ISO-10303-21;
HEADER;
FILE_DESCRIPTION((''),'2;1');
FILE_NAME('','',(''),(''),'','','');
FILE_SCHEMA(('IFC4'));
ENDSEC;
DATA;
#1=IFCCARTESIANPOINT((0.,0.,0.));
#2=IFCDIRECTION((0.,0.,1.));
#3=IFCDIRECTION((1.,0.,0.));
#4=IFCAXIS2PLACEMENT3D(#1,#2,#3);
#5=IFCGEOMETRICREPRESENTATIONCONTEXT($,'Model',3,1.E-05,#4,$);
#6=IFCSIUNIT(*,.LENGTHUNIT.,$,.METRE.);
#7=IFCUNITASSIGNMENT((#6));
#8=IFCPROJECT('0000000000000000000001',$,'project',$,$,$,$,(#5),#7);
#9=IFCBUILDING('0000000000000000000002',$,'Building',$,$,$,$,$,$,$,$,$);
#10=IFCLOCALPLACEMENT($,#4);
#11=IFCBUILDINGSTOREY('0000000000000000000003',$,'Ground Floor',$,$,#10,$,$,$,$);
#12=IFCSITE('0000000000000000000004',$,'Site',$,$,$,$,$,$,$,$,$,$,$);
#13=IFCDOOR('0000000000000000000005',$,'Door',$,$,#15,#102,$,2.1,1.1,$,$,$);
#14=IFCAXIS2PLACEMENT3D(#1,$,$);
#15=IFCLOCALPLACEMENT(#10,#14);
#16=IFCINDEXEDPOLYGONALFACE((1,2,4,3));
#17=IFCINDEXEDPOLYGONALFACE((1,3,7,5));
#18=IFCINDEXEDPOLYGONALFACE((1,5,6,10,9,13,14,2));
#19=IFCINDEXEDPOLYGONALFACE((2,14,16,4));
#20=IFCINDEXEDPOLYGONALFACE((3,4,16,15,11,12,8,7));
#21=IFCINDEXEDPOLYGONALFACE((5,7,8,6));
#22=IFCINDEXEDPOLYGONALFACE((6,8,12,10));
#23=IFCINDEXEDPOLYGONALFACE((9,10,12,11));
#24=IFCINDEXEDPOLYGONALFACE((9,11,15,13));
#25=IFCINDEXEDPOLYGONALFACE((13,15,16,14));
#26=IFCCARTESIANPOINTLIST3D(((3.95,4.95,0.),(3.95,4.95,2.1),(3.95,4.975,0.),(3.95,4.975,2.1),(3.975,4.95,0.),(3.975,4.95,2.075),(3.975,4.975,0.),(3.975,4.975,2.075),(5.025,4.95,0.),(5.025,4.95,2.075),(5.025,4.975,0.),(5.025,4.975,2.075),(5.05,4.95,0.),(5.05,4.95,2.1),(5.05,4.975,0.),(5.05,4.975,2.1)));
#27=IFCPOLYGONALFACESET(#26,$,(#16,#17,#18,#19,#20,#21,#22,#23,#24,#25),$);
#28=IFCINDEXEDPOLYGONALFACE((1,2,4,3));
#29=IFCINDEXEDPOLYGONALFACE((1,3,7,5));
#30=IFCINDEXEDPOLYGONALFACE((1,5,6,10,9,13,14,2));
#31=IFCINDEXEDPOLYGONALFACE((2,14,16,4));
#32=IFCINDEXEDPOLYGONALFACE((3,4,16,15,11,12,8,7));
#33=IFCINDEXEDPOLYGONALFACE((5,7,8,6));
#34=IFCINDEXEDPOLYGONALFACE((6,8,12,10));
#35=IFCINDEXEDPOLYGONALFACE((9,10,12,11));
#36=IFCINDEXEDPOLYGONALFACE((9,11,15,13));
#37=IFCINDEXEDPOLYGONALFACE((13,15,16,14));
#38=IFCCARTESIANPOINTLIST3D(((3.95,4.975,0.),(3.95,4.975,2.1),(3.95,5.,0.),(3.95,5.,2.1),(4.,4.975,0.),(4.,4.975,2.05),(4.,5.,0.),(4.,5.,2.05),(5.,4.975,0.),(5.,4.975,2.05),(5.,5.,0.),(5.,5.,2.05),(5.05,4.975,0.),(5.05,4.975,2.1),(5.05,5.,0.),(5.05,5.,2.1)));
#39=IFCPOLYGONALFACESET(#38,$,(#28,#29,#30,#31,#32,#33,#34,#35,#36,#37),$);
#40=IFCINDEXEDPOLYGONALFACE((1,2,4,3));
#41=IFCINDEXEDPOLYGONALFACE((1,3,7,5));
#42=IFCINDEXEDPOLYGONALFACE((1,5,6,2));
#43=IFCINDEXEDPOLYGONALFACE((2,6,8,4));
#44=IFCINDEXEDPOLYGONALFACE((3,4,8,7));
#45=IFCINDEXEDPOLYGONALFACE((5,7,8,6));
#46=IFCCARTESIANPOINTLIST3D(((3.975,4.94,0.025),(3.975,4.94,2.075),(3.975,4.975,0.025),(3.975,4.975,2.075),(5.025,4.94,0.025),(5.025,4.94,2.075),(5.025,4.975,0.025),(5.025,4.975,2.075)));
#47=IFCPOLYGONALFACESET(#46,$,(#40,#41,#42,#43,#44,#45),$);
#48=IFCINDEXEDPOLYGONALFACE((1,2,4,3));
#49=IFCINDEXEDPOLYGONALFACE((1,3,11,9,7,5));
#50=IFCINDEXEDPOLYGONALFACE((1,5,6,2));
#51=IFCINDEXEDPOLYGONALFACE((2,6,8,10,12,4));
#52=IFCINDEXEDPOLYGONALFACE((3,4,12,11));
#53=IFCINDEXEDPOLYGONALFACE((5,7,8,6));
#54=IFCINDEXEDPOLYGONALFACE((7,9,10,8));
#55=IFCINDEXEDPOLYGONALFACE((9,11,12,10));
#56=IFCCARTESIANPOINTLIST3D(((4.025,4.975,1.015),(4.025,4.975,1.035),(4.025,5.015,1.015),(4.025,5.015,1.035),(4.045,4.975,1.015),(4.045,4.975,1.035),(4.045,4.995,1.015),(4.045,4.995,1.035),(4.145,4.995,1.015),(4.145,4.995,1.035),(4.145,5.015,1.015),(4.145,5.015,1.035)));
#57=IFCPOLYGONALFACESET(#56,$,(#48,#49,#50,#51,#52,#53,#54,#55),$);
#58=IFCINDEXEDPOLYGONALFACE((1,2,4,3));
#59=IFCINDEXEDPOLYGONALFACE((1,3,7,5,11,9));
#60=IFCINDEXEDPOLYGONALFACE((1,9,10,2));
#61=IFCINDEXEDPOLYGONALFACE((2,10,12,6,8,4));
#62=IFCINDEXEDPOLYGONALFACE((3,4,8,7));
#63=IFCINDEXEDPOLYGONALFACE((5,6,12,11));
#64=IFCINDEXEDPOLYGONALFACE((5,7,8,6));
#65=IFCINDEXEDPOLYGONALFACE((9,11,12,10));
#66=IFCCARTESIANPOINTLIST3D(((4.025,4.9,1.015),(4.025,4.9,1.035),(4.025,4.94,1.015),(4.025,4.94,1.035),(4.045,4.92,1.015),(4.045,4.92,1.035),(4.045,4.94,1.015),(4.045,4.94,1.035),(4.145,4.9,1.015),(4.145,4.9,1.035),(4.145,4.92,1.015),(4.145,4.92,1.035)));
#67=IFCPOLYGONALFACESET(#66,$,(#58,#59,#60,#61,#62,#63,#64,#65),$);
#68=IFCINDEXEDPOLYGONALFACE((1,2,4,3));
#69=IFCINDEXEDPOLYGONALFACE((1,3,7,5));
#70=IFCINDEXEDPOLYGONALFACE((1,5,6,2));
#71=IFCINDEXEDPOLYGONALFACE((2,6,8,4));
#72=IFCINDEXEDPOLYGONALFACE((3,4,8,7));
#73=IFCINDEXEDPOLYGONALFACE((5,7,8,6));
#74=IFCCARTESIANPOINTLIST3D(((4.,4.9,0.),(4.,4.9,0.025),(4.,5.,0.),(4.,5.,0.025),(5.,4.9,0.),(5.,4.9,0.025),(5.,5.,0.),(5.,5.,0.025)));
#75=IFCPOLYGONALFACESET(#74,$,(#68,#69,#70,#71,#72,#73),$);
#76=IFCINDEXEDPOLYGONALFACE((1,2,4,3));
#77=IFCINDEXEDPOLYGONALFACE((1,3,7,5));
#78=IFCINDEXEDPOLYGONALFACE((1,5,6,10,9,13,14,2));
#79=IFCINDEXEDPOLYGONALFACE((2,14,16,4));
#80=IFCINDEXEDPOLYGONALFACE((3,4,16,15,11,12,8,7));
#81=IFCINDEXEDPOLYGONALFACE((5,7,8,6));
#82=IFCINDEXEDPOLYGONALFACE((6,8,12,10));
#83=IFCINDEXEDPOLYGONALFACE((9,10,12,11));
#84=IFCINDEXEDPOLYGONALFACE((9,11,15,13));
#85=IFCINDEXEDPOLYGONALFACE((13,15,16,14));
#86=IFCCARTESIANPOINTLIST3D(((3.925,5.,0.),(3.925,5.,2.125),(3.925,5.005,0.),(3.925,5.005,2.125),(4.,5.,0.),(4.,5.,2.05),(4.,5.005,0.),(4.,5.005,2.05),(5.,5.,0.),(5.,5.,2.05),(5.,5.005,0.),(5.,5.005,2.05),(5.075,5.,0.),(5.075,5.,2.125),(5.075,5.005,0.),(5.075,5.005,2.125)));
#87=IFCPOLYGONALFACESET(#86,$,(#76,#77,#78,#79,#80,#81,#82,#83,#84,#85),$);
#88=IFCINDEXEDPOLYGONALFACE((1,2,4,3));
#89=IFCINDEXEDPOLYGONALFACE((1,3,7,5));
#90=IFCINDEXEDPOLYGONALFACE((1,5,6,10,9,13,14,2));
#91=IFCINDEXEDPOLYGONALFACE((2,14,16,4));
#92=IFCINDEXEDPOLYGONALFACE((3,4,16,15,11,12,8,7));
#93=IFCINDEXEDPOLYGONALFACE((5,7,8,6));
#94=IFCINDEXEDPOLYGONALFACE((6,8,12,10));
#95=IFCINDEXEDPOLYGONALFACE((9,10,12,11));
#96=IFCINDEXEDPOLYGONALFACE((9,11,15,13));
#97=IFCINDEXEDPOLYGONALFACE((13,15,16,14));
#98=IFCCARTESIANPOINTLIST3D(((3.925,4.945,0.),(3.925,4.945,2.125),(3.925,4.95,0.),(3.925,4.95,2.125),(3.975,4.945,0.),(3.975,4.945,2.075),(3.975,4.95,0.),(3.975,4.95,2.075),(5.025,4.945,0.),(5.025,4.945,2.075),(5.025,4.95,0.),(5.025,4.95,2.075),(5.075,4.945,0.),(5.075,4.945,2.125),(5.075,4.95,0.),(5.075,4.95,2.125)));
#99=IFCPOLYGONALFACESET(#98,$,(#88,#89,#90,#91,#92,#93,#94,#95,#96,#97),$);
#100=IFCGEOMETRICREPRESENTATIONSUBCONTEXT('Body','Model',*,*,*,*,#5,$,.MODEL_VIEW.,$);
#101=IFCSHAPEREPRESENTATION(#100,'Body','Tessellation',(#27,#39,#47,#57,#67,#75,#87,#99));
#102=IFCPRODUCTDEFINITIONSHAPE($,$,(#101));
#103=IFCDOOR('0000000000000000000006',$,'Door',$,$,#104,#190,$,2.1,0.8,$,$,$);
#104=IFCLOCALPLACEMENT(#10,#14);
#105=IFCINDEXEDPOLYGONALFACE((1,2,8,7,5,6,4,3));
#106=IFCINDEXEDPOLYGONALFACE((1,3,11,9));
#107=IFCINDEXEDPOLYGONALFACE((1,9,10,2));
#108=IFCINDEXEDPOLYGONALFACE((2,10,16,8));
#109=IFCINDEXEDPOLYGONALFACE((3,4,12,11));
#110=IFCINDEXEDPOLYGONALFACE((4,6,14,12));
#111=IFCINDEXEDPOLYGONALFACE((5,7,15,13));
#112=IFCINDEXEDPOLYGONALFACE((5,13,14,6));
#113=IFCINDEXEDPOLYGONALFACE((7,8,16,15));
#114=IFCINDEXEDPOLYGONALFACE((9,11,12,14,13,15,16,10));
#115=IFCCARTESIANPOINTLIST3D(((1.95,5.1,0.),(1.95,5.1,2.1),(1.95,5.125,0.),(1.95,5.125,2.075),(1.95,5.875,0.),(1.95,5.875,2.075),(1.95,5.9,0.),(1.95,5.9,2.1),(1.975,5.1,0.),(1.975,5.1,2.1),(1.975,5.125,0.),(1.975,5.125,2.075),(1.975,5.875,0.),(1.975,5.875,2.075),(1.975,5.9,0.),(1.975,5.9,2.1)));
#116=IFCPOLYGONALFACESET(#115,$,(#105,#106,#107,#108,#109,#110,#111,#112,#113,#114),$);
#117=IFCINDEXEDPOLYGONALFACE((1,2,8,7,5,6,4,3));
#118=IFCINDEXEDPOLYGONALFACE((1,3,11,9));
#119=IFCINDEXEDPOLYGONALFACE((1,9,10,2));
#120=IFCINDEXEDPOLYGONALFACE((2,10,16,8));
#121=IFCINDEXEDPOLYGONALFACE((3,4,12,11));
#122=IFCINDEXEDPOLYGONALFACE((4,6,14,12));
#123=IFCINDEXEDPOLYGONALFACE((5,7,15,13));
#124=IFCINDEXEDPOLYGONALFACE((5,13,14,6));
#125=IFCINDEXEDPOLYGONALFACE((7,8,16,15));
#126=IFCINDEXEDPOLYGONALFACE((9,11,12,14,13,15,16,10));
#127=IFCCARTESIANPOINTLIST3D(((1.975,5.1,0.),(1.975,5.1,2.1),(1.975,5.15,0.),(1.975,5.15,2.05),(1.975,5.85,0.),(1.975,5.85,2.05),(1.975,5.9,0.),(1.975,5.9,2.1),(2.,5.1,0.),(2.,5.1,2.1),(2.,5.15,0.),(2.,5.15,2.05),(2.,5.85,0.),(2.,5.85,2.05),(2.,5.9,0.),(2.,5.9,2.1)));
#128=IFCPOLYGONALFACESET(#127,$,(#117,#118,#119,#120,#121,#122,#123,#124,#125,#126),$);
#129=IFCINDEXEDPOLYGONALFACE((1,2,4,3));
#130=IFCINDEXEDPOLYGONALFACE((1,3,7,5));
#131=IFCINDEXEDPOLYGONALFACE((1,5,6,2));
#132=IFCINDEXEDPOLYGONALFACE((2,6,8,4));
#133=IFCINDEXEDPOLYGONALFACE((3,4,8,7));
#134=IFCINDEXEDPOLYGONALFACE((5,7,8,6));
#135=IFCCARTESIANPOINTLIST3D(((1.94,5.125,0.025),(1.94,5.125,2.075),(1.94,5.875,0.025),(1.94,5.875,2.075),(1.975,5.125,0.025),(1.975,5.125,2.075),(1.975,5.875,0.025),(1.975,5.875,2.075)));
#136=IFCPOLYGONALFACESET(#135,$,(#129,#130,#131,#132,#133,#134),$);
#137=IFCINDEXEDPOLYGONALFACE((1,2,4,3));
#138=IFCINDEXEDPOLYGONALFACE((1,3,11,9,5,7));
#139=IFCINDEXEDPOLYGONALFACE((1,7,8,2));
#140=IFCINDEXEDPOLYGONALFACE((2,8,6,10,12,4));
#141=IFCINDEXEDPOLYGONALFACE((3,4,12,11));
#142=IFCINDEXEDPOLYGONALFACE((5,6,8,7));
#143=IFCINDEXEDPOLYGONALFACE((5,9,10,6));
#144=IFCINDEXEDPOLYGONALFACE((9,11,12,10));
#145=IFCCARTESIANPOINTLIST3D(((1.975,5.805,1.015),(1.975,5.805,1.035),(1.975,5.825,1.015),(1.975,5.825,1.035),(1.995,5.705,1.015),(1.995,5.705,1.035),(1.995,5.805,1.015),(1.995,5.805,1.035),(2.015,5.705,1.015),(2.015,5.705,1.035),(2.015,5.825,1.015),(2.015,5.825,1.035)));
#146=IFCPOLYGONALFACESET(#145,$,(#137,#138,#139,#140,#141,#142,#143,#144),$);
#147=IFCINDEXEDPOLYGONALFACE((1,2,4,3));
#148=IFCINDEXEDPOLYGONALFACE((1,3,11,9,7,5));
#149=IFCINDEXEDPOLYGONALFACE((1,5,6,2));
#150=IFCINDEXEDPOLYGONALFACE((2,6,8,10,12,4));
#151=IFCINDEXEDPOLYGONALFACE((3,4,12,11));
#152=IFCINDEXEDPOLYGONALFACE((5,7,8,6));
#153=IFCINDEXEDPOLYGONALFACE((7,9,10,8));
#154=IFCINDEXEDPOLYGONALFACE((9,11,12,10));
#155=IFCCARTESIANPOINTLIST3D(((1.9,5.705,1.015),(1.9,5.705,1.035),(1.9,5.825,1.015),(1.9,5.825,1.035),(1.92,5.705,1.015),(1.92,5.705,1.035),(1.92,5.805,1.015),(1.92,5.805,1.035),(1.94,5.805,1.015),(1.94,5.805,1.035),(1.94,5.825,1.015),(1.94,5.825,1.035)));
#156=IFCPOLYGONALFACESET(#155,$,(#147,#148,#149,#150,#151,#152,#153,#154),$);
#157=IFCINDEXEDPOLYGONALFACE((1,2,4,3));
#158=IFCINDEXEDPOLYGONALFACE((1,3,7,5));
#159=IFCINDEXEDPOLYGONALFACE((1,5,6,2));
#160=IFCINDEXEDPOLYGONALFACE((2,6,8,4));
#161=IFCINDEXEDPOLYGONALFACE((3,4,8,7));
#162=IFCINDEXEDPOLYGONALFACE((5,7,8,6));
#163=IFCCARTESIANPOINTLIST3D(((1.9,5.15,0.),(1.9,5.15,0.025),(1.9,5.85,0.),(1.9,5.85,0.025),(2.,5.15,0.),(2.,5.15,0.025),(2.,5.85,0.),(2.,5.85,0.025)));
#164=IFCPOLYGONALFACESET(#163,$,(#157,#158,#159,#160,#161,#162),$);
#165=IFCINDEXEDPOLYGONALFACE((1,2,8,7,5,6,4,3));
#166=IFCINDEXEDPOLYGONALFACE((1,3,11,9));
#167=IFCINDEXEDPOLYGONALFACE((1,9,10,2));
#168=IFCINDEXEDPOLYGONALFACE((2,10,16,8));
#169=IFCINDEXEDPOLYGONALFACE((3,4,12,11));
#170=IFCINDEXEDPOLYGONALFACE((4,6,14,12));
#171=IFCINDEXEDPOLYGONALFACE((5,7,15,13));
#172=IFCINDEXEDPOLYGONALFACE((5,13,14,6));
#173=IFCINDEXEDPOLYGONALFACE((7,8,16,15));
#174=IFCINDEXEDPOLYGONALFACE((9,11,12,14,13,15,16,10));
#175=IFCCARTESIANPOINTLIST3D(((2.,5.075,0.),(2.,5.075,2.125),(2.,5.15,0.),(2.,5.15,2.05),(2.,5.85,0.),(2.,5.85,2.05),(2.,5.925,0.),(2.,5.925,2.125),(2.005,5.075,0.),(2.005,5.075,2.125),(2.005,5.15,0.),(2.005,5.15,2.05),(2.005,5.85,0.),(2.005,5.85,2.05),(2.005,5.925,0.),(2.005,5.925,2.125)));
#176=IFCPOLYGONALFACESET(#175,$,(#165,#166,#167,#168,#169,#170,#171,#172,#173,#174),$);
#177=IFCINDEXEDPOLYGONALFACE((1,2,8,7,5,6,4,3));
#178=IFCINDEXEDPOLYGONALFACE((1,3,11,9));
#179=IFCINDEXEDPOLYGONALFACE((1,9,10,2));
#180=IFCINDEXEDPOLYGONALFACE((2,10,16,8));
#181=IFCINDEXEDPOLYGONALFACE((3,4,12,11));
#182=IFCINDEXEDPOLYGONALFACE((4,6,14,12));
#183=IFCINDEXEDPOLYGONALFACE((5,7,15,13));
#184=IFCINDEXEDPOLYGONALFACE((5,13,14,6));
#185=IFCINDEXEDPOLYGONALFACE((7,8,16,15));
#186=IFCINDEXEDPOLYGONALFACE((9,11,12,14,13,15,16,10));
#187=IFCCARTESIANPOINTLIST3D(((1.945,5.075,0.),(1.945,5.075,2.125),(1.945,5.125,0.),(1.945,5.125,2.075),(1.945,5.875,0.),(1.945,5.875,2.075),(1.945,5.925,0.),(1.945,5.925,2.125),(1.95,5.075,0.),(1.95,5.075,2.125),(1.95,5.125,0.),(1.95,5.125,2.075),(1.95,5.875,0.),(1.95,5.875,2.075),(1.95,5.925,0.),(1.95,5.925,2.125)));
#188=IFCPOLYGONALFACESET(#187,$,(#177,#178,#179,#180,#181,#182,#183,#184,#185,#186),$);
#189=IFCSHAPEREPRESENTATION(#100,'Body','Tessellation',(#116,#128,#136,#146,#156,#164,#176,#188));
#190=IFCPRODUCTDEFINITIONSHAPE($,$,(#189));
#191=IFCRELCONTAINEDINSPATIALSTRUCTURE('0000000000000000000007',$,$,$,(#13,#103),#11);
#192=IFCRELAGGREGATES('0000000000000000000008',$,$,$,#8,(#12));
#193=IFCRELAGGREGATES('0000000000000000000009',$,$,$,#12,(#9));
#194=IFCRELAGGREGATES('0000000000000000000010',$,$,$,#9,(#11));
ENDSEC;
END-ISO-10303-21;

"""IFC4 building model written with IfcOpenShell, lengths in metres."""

from ifc_helpers import new_model, si_unit, frame, origin_with_axes, place, context, subcontext, project, spatial, line, indexed_curve, outline, extrude, element, save


model = new_model("IFC4")

# Units and contexts
model_context = context("Model", 3, precision=1e-05, world=origin_with_axes())
body_context = subcontext(model_context, "Body", "Model", "MODEL_VIEW")
ifc_project = project(units=[si_unit("LENGTHUNIT", "METRE")], contexts=[model_context])

# Site, building, storey
site = spatial("IfcSite", under=ifc_project, Name="Site")
building = spatial("IfcBuilding", under=site, Name="Building")
storey_placement = place(None, origin_with_axes())
storey = spatial("IfcBuildingStorey", under=building, at=storey_placement, Name="Ground Floor")

# Doors
door_1_placement = place(storey_placement, frame((5.05, 5.0, 0.0), z_axis=(0.0, 0.0, 1.0), x_axis=(-1.0, 0.0, 0.0)))
element("IfcDoor", 1, at=door_1_placement, inside=storey, Name="Door", OverallHeight=2.1, OverallWidth=1.1, context=body_context, shape_type="SweptSolid", body=[
    extrude(outline(indexed_curve([(0.0, 0.0), (0.0, 2.1), (1.1, 2.1), (1.1, 0.0), (1.075, 0.0), (1.075, 2.075), (0.025, 2.075), (0.025, 0.0)], segments=[line(1, 2, 3, 4, 5, 6, 7, 8, 1)])), frame((0.0, 0.025, 0.0), z_axis=(0.0, -1.0, 0.0), x_axis=(1.0, 0.0, 0.0)), (0.0, 0.0, -1.0), 0.025),
    extrude(outline(indexed_curve([(0.0, 0.0), (0.0, 2.1), (1.1, 2.1), (1.1, 0.0), (1.05, 0.0), (1.05, 2.05), (0.05, 2.05), (0.05, 0.0)], segments=[line(1, 2, 3, 4, 5, 6, 7, 8, 1)])), frame((0.0, 0.0, 0.0), z_axis=(0.0, -1.0, 0.0), x_axis=(1.0, 0.0, 0.0)), (0.0, 0.0, -1.0), 0.025),
    extrude(outline(indexed_curve([(0.0, 0.0), (1.05, 0.0), (1.05, 0.035), (0.0, 0.035)], segments=[line(1, 2, 3, 4, 1)])), frame((0.025, 0.025, 0.025), z_axis=(0.0, 0.0, 1.0), x_axis=(1.0, 0.0, 0.0)), (0.0, 0.0, 1.0), 2.05),
    extrude(outline(indexed_curve([(0.0, 0.0), (0.0, -0.04), (-0.12, -0.04), (-0.12, -0.02), (-0.02, -0.02), (-0.02, 0.0)], segments=[line(1, 2, 3, 4, 5, 6, 1)])), frame((1.025, 0.025, 1.015), z_axis=(0.0, 0.0, 1.0), x_axis=(1.0, 0.0, 0.0)), (0.0, 0.0, 1.0), 0.02),
    extrude(outline(indexed_curve([(0.0, 0.0), (0.0, 0.04), (-0.12, 0.04), (-0.12, 0.02), (-0.02, 0.02), (-0.02, 0.0)], segments=[line(1, 2, 3, 4, 5, 6, 1)])), frame((1.025, 0.06, 1.015), z_axis=(0.0, 0.0, 1.0), x_axis=(1.0, 0.0, 0.0)), (0.0, 0.0, 1.0), 0.02),
    extrude(outline(indexed_curve([(0.0, 0.0), (1.0, 0.0), (1.0, 0.1), (0.0, 0.1)], segments=[line(1, 2, 3, 4, 1)])), frame((0.05, 0.0, 0.0), z_axis=(0.0, 0.0, 1.0), x_axis=(1.0, 0.0, 0.0)), (0.0, 0.0, 1.0), 0.025),
    extrude(outline(indexed_curve([(0.0, 0.0), (0.0, 2.125), (1.15, 2.125), (1.15, 0.0), (1.075, 0.0), (1.075, 2.05), (0.075, 2.05), (0.075, 0.0)], segments=[line(1, 2, 3, 4, 5, 6, 7, 8, 1)])), frame((-0.025, -0.005, 0.0), z_axis=(0.0, -1.0, 0.0), x_axis=(1.0, 0.0, 0.0)), (0.0, 0.0, -1.0), 0.005),
    extrude(outline(indexed_curve([(0.0, 0.0), (0.0, 2.125), (1.15, 2.125), (1.15, 0.0), (1.1, 0.0), (1.1, 2.075), (0.05, 2.075), (0.05, 0.0)], segments=[line(1, 2, 3, 4, 5, 6, 7, 8, 1)])), frame((-0.025, 0.05, 0.0), z_axis=(0.0, -1.0, 0.0), x_axis=(1.0, 0.0, 0.0)), (0.0, 0.0, -1.0), 0.005),
])
door_2_placement = place(storey_placement, frame((2.0, 5.1, 0.0), z_axis=(0.0, 0.0, 1.0), x_axis=(0.0, 1.0, 0.0)))
element("IfcDoor", 2, at=door_2_placement, inside=storey, Name="Door", OverallHeight=2.1, OverallWidth=0.8, context=body_context, shape_type="SweptSolid", body=[
    extrude(outline(indexed_curve([(0.0, 0.0), (0.0, 2.1), (0.8, 2.1), (0.8, 0.0), (0.775, 0.0), (0.775, 2.075), (0.025, 2.075), (0.025, 0.0)], segments=[line(1, 2, 3, 4, 5, 6, 7, 8, 1)])), frame((0.0, 0.025, 0.0), z_axis=(0.0, -1.0, 0.0), x_axis=(1.0, 0.0, 0.0)), (0.0, 0.0, -1.0), 0.025),
    extrude(outline(indexed_curve([(0.0, 0.0), (0.0, 2.1), (0.8, 2.1), (0.8, 0.0), (0.75, 0.0), (0.75, 2.05), (0.05, 2.05), (0.05, 0.0)], segments=[line(1, 2, 3, 4, 5, 6, 7, 8, 1)])), frame((0.0, 0.0, 0.0), z_axis=(0.0, -1.0, 0.0), x_axis=(1.0, 0.0, 0.0)), (0.0, 0.0, -1.0), 0.025),
    extrude(outline(indexed_curve([(0.0, 0.0), (0.75, 0.0), (0.75, 0.035), (0.0, 0.035)], segments=[line(1, 2, 3, 4, 1)])), frame((0.025, 0.025, 0.025), z_axis=(0.0, 0.0, 1.0), x_axis=(1.0, 0.0, 0.0)), (0.0, 0.0, 1.0), 2.05),
    extrude(outline(indexed_curve([(0.0, 0.0), (0.0, -0.04), (-0.12, -0.04), (-0.12, -0.02), (-0.02, -0.02), (-0.02, 0.0)], segments=[line(1, 2, 3, 4, 5, 6, 1)])), frame((0.725, 0.025, 1.015), z_axis=(0.0, 0.0, 1.0), x_axis=(1.0, 0.0, 0.0)), (0.0, 0.0, 1.0), 0.02),
    extrude(outline(indexed_curve([(0.0, 0.0), (0.0, 0.04), (-0.12, 0.04), (-0.12, 0.02), (-0.02, 0.02), (-0.02, 0.0)], segments=[line(1, 2, 3, 4, 5, 6, 1)])), frame((0.725, 0.06, 1.015), z_axis=(0.0, 0.0, 1.0), x_axis=(1.0, 0.0, 0.0)), (0.0, 0.0, 1.0), 0.02),
    extrude(outline(indexed_curve([(0.0, 0.0), (0.7, 0.0), (0.7, 0.1), (0.0, 0.1)], segments=[line(1, 2, 3, 4, 1)])), frame((0.05, 0.0, 0.0), z_axis=(0.0, 0.0, 1.0), x_axis=(1.0, 0.0, 0.0)), (0.0, 0.0, 1.0), 0.025),
    extrude(outline(indexed_curve([(0.0, 0.0), (0.0, 2.125), (0.85, 2.125), (0.85, 0.0), (0.775, 0.0), (0.775, 2.05), (0.075, 2.05), (0.075, 0.0)], segments=[line(1, 2, 3, 4, 5, 6, 7, 8, 1)])), frame((-0.025, -0.005, 0.0), z_axis=(0.0, -1.0, 0.0), x_axis=(1.0, 0.0, 0.0)), (0.0, 0.0, -1.0), 0.005),
    extrude(outline(indexed_curve([(0.0, 0.0), (0.0, 2.125), (0.85, 2.125), (0.85, 0.0), (0.8, 0.0), (0.8, 2.075), (0.05, 2.075), (0.05, 0.0)], segments=[line(1, 2, 3, 4, 5, 6, 7, 8, 1)])), frame((-0.025, 0.05, 0.0), z_axis=(0.0, -1.0, 0.0), x_axis=(1.0, 0.0, 0.0)), (0.0, 0.0, -1.0), 0.005),
])

save(model, "model.ifc")
